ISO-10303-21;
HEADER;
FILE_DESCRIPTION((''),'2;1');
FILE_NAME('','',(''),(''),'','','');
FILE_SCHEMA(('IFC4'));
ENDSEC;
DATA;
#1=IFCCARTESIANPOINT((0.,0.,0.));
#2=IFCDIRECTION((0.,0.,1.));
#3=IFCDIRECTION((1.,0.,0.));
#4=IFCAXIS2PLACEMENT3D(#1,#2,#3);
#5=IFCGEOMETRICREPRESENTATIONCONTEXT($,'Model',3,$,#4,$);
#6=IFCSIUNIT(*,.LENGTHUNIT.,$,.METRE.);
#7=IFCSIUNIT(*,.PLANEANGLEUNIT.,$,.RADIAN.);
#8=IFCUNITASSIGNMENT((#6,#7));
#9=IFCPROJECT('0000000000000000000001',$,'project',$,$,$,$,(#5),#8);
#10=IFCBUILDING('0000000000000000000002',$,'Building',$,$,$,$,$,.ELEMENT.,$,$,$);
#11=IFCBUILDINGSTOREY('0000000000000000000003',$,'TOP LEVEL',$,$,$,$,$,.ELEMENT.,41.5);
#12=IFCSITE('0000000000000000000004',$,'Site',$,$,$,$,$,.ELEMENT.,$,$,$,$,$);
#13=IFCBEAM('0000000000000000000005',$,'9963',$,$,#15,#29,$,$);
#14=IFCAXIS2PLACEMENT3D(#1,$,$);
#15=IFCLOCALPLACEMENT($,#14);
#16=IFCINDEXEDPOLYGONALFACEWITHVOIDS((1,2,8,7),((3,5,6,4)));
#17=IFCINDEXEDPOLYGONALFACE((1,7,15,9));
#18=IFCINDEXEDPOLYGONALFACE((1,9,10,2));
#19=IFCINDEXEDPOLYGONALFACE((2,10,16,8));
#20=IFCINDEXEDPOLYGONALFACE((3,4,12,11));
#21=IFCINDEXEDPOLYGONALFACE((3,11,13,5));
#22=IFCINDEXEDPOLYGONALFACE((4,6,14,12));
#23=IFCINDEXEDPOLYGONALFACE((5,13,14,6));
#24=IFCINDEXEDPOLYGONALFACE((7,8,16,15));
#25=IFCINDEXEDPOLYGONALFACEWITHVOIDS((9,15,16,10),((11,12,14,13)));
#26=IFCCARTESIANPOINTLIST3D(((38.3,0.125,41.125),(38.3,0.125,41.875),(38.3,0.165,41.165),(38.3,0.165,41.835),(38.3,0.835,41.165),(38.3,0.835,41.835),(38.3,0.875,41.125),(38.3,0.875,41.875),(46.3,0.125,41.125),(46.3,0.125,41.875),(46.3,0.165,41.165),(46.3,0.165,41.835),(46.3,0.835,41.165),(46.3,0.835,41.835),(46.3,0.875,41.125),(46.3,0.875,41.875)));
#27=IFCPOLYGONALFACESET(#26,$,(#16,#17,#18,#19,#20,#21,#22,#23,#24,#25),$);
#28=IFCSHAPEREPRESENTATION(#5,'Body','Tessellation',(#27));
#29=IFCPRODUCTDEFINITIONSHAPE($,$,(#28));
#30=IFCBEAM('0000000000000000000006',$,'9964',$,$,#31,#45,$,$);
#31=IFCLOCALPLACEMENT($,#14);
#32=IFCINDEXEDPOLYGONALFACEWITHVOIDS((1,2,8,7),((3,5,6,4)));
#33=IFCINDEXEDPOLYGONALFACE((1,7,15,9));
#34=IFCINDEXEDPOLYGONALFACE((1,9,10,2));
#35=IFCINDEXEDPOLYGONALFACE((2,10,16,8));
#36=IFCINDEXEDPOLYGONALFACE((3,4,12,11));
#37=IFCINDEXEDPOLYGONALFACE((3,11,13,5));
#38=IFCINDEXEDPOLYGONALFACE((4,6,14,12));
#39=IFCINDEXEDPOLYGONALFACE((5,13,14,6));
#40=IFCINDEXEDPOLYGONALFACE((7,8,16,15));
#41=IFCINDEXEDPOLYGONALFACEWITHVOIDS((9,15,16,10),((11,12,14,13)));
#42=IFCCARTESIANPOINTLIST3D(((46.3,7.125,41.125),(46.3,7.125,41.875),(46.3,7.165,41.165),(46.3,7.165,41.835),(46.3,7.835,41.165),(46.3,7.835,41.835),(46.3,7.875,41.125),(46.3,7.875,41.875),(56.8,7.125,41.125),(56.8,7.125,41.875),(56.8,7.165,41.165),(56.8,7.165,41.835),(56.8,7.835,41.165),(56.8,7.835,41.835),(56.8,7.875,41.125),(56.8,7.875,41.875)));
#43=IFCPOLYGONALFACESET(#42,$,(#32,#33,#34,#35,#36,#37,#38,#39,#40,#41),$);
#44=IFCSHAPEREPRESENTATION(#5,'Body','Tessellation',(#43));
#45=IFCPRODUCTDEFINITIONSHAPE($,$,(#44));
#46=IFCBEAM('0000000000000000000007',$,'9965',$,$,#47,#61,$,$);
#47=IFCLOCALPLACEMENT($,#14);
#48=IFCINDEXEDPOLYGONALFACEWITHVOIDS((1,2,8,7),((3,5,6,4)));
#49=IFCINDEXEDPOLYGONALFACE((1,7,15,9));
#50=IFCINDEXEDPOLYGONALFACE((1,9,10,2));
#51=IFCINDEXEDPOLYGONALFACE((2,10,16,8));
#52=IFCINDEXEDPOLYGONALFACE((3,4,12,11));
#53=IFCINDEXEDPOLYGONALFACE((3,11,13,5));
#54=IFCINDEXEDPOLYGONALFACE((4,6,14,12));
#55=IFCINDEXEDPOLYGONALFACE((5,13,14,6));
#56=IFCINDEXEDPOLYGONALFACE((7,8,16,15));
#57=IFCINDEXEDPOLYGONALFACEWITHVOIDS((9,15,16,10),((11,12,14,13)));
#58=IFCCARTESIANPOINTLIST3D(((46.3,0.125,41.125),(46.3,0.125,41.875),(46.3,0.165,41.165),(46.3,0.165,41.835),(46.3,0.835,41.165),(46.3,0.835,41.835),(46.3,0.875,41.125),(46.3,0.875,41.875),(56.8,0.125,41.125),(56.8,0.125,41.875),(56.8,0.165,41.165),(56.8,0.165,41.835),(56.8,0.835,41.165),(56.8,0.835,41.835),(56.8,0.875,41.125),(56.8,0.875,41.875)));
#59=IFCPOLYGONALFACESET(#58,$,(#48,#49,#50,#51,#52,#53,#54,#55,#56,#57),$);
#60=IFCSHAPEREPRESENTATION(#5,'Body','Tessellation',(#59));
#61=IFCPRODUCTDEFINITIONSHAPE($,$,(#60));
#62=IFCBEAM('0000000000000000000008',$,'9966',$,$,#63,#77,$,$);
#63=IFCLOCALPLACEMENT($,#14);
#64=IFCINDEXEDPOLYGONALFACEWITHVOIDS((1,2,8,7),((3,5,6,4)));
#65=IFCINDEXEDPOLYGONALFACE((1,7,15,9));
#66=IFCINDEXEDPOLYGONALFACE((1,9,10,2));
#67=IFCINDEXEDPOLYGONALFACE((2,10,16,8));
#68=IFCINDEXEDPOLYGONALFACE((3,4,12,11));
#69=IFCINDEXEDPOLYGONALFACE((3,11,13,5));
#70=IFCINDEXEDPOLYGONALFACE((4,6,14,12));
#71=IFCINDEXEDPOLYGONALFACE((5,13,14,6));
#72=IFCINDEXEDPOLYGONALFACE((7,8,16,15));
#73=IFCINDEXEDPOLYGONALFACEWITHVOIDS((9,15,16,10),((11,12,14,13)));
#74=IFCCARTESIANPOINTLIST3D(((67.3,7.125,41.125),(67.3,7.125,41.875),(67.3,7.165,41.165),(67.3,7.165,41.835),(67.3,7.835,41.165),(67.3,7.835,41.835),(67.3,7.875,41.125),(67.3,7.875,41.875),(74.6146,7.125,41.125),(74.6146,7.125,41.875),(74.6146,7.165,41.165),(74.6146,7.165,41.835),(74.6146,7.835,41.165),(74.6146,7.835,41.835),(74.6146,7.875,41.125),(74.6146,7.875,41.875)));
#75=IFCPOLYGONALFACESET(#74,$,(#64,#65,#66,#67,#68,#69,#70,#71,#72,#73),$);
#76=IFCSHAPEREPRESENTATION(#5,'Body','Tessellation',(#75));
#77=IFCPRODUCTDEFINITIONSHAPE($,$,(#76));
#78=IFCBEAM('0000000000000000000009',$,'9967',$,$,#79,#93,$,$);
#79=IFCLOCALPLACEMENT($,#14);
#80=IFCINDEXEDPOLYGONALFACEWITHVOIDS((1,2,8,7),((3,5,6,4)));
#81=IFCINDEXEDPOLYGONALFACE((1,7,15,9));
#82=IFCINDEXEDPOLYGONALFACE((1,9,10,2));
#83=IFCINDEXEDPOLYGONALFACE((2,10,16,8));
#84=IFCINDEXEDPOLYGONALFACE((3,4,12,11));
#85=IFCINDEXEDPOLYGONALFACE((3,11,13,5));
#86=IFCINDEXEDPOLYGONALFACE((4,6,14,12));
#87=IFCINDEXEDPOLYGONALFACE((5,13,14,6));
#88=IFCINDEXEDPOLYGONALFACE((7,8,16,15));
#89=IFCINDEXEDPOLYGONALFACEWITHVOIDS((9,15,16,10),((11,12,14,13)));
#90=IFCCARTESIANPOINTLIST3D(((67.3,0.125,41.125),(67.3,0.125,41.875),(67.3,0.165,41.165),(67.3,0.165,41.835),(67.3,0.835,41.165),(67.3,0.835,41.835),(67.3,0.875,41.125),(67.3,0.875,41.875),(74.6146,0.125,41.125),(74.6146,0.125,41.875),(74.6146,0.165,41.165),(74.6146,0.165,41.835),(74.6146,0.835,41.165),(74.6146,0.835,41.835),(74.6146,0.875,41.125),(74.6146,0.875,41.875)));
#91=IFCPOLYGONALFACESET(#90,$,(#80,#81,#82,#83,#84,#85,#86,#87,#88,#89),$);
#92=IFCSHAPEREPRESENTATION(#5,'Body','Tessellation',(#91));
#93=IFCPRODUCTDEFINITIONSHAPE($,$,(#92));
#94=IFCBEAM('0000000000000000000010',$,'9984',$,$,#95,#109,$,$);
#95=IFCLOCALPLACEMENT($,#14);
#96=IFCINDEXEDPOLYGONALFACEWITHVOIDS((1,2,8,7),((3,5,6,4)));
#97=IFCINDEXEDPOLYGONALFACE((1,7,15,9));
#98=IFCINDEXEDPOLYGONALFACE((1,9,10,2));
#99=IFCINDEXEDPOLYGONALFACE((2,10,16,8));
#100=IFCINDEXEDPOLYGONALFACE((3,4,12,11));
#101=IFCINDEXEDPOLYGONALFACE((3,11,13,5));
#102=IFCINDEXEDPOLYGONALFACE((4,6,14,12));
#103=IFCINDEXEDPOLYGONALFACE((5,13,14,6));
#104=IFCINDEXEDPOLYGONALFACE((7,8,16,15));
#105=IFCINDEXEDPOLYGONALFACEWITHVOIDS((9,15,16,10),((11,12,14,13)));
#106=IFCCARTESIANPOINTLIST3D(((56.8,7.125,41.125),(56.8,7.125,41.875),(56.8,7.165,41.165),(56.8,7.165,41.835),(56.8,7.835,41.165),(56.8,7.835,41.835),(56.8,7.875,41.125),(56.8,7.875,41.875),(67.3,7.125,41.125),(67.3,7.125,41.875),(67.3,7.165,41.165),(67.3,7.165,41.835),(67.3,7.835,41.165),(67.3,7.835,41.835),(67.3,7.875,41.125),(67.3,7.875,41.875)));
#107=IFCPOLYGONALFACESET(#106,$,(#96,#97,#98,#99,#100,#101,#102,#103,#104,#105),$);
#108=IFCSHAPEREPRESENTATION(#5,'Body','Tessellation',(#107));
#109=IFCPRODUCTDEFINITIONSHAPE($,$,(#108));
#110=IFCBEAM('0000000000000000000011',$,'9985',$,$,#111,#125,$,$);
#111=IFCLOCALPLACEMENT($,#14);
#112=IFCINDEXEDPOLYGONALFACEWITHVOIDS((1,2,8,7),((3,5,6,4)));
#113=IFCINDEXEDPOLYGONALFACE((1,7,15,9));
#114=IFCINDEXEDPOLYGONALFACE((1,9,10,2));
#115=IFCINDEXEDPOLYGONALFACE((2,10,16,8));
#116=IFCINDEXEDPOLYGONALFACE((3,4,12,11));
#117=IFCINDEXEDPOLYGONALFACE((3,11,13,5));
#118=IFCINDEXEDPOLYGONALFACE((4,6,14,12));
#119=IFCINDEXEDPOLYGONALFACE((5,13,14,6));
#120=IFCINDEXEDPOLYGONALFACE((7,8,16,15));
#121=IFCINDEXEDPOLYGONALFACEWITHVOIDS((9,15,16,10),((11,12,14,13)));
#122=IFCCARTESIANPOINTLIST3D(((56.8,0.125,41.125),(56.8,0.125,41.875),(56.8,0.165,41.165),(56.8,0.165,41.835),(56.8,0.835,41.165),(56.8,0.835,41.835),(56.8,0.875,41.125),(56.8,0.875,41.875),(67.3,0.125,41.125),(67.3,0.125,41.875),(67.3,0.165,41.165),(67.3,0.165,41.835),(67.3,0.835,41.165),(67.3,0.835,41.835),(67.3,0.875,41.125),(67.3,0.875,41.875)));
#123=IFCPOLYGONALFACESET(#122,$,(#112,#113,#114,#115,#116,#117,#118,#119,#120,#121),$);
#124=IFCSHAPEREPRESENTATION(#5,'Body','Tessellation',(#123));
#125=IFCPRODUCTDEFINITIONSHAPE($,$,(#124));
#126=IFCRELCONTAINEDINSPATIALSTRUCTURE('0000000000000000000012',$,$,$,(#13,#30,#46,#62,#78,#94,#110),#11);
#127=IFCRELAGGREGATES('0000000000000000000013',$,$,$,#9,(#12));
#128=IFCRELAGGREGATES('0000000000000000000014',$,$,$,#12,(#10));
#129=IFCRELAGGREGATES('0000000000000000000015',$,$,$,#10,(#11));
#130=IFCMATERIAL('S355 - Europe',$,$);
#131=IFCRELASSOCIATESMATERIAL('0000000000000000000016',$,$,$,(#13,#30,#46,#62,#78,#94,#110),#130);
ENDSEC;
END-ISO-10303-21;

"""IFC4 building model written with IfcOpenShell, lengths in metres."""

from ifc_helpers import new_model, si_unit, frame, origin_with_axes, origin_2d_with_axis, place, context, project, spatial, hollow_rectangle, extrude, material, material_profile, profile_set, profile_usage, element, save


model = new_model("IFC4")

# Units and contexts
model_context = context("Model", 3, world=origin_with_axes())
ifc_project = project(units=[si_unit("LENGTHUNIT", "METRE"), si_unit("PLANEANGLEUNIT", "RADIAN")], contexts=[model_context])

# Site, building, storey
site = spatial("IfcSite", under=ifc_project, Name="Site", CompositionType="ELEMENT")
building = spatial("IfcBuilding", under=site, Name="Building", CompositionType="ELEMENT")
storey = spatial("IfcBuildingStorey", under=building, Name="TOP LEVEL", CompositionType="ELEMENT", Elevation=41.5)

# Beams
ifc_material = material(Name="S355 - Europe")
ifc_material_profile_1 = material_profile(ifc_material, hollow_rectangle(XDim=0.75, YDim=0.75, WallThickness=0.04, at=origin_2d_with_axis()))
ifc_profile_set_1 = profile_set([ifc_material_profile_1])
ifc_profile_usage_1 = profile_usage(ifc_profile_set_1, cardinal=10)
beam_1_placement = place(None, frame((46.3, 0.5, 41.5), z_axis=(-1.0, 0.0, 0.0), x_axis=(0.0, -1.0, 0.0)))
element("IfcBeam", 1, at=beam_1_placement, inside=storey, material=ifc_profile_usage_1, Name="9963", context=model_context, shape_type="SweptSolid", body=[
    extrude(hollow_rectangle(XDim=0.75, YDim=0.75, WallThickness=0.04, at=origin_2d_with_axis()), origin_with_axes(), (0.0, 0.0, 1.0), 8.0),
])
ifc_material_profile_2 = material_profile(ifc_material, hollow_rectangle(XDim=0.75, YDim=0.75, WallThickness=0.04, at=origin_2d_with_axis()))
ifc_profile_set_2 = profile_set([ifc_material_profile_2])
ifc_profile_usage_2 = profile_usage(ifc_profile_set_2, cardinal=10)
beam_2_placement = place(None, frame((56.8, 7.5, 41.5), z_axis=(-1.0, 0.0, 0.0), x_axis=(0.0, -1.0, 0.0)))
element("IfcBeam", 2, at=beam_2_placement, inside=storey, material=ifc_profile_usage_2, Name="9964", context=model_context, shape_type="SweptSolid", body=[
    extrude(hollow_rectangle(XDim=0.75, YDim=0.75, WallThickness=0.04, at=origin_2d_with_axis()), origin_with_axes(), (0.0, 0.0, 1.0), 10.5),
])
ifc_material_profile_3 = material_profile(ifc_material, hollow_rectangle(XDim=0.75, YDim=0.75, WallThickness=0.04, at=origin_2d_with_axis()))
ifc_profile_set_3 = profile_set([ifc_material_profile_3])
ifc_profile_usage_3 = profile_usage(ifc_profile_set_3, cardinal=10)
beam_3_placement = place(None, frame((56.8, 0.5, 41.5), z_axis=(-1.0, 0.0, 0.0), x_axis=(0.0, -1.0, 0.0)))
element("IfcBeam", 3, at=beam_3_placement, inside=storey, material=ifc_profile_usage_3, Name="9965", context=model_context, shape_type="SweptSolid", body=[
    extrude(hollow_rectangle(XDim=0.75, YDim=0.75, WallThickness=0.04, at=origin_2d_with_axis()), origin_with_axes(), (0.0, 0.0, 1.0), 10.5),
])
ifc_material_profile_4 = material_profile(ifc_material, hollow_rectangle(XDim=0.75, YDim=0.75, WallThickness=0.04, at=origin_2d_with_axis()))
ifc_profile_set_4 = profile_set([ifc_material_profile_4])
ifc_profile_usage_4 = profile_usage(ifc_profile_set_4, cardinal=10)
beam_4_placement = place(None, frame((74.6146, 7.5, 41.5), z_axis=(-1.0, 0.0, 0.0), x_axis=(0.0, -1.0, 0.0)))
element("IfcBeam", 4, at=beam_4_placement, inside=storey, material=ifc_profile_usage_4, Name="9966", context=model_context, shape_type="SweptSolid", body=[
    extrude(hollow_rectangle(XDim=0.75, YDim=0.75, WallThickness=0.04, at=origin_2d_with_axis()), origin_with_axes(), (0.0, 0.0, 1.0), 7.3146),
])
ifc_material_profile_5 = material_profile(ifc_material, hollow_rectangle(XDim=0.75, YDim=0.75, WallThickness=0.04, at=origin_2d_with_axis()))
ifc_profile_set_5 = profile_set([ifc_material_profile_5])
ifc_profile_usage_5 = profile_usage(ifc_profile_set_5, cardinal=10)
beam_5_placement = place(None, frame((74.6146, 0.5, 41.5), z_axis=(-1.0, 0.0, 0.0), x_axis=(0.0, -1.0, 0.0)))
element("IfcBeam", 5, at=beam_5_placement, inside=storey, material=ifc_profile_usage_5, Name="9967", context=model_context, shape_type="SweptSolid", body=[
    extrude(hollow_rectangle(XDim=0.75, YDim=0.75, WallThickness=0.04, at=origin_2d_with_axis()), origin_with_axes(), (0.0, 0.0, 1.0), 7.3146),
])
ifc_material_profile_6 = material_profile(ifc_material, hollow_rectangle(XDim=0.75, YDim=0.75, WallThickness=0.04, at=origin_2d_with_axis()))
ifc_profile_set_6 = profile_set([ifc_material_profile_6])
ifc_profile_usage_6 = profile_usage(ifc_profile_set_6, cardinal=10)
beam_6_placement = place(None, frame((67.3, 7.5, 41.5), z_axis=(-1.0, 0.0, 0.0), x_axis=(0.0, -1.0, 0.0)))
element("IfcBeam", 6, at=beam_6_placement, inside=storey, material=ifc_profile_usage_6, Name="9984", context=model_context, shape_type="SweptSolid", body=[
    extrude(hollow_rectangle(XDim=0.75, YDim=0.75, WallThickness=0.04, at=origin_2d_with_axis()), origin_with_axes(), (0.0, 0.0, 1.0), 10.5),
])
ifc_material_profile_7 = material_profile(ifc_material, hollow_rectangle(XDim=0.75, YDim=0.75, WallThickness=0.04, at=origin_2d_with_axis()))
ifc_profile_set_7 = profile_set([ifc_material_profile_7])
ifc_profile_usage_7 = profile_usage(ifc_profile_set_7, cardinal=10)
beam_7_placement = place(None, frame((67.3, 0.5, 41.5), z_axis=(-1.0, 0.0, 0.0), x_axis=(0.0, -1.0, 0.0)))
element("IfcBeam", 7, at=beam_7_placement, inside=storey, material=ifc_profile_usage_7, Name="9985", context=model_context, shape_type="SweptSolid", body=[
    extrude(hollow_rectangle(XDim=0.75, YDim=0.75, WallThickness=0.04, at=origin_2d_with_axis()), origin_with_axes(), (0.0, 0.0, 1.0), 10.5),
])

save(model, "model.ifc")
